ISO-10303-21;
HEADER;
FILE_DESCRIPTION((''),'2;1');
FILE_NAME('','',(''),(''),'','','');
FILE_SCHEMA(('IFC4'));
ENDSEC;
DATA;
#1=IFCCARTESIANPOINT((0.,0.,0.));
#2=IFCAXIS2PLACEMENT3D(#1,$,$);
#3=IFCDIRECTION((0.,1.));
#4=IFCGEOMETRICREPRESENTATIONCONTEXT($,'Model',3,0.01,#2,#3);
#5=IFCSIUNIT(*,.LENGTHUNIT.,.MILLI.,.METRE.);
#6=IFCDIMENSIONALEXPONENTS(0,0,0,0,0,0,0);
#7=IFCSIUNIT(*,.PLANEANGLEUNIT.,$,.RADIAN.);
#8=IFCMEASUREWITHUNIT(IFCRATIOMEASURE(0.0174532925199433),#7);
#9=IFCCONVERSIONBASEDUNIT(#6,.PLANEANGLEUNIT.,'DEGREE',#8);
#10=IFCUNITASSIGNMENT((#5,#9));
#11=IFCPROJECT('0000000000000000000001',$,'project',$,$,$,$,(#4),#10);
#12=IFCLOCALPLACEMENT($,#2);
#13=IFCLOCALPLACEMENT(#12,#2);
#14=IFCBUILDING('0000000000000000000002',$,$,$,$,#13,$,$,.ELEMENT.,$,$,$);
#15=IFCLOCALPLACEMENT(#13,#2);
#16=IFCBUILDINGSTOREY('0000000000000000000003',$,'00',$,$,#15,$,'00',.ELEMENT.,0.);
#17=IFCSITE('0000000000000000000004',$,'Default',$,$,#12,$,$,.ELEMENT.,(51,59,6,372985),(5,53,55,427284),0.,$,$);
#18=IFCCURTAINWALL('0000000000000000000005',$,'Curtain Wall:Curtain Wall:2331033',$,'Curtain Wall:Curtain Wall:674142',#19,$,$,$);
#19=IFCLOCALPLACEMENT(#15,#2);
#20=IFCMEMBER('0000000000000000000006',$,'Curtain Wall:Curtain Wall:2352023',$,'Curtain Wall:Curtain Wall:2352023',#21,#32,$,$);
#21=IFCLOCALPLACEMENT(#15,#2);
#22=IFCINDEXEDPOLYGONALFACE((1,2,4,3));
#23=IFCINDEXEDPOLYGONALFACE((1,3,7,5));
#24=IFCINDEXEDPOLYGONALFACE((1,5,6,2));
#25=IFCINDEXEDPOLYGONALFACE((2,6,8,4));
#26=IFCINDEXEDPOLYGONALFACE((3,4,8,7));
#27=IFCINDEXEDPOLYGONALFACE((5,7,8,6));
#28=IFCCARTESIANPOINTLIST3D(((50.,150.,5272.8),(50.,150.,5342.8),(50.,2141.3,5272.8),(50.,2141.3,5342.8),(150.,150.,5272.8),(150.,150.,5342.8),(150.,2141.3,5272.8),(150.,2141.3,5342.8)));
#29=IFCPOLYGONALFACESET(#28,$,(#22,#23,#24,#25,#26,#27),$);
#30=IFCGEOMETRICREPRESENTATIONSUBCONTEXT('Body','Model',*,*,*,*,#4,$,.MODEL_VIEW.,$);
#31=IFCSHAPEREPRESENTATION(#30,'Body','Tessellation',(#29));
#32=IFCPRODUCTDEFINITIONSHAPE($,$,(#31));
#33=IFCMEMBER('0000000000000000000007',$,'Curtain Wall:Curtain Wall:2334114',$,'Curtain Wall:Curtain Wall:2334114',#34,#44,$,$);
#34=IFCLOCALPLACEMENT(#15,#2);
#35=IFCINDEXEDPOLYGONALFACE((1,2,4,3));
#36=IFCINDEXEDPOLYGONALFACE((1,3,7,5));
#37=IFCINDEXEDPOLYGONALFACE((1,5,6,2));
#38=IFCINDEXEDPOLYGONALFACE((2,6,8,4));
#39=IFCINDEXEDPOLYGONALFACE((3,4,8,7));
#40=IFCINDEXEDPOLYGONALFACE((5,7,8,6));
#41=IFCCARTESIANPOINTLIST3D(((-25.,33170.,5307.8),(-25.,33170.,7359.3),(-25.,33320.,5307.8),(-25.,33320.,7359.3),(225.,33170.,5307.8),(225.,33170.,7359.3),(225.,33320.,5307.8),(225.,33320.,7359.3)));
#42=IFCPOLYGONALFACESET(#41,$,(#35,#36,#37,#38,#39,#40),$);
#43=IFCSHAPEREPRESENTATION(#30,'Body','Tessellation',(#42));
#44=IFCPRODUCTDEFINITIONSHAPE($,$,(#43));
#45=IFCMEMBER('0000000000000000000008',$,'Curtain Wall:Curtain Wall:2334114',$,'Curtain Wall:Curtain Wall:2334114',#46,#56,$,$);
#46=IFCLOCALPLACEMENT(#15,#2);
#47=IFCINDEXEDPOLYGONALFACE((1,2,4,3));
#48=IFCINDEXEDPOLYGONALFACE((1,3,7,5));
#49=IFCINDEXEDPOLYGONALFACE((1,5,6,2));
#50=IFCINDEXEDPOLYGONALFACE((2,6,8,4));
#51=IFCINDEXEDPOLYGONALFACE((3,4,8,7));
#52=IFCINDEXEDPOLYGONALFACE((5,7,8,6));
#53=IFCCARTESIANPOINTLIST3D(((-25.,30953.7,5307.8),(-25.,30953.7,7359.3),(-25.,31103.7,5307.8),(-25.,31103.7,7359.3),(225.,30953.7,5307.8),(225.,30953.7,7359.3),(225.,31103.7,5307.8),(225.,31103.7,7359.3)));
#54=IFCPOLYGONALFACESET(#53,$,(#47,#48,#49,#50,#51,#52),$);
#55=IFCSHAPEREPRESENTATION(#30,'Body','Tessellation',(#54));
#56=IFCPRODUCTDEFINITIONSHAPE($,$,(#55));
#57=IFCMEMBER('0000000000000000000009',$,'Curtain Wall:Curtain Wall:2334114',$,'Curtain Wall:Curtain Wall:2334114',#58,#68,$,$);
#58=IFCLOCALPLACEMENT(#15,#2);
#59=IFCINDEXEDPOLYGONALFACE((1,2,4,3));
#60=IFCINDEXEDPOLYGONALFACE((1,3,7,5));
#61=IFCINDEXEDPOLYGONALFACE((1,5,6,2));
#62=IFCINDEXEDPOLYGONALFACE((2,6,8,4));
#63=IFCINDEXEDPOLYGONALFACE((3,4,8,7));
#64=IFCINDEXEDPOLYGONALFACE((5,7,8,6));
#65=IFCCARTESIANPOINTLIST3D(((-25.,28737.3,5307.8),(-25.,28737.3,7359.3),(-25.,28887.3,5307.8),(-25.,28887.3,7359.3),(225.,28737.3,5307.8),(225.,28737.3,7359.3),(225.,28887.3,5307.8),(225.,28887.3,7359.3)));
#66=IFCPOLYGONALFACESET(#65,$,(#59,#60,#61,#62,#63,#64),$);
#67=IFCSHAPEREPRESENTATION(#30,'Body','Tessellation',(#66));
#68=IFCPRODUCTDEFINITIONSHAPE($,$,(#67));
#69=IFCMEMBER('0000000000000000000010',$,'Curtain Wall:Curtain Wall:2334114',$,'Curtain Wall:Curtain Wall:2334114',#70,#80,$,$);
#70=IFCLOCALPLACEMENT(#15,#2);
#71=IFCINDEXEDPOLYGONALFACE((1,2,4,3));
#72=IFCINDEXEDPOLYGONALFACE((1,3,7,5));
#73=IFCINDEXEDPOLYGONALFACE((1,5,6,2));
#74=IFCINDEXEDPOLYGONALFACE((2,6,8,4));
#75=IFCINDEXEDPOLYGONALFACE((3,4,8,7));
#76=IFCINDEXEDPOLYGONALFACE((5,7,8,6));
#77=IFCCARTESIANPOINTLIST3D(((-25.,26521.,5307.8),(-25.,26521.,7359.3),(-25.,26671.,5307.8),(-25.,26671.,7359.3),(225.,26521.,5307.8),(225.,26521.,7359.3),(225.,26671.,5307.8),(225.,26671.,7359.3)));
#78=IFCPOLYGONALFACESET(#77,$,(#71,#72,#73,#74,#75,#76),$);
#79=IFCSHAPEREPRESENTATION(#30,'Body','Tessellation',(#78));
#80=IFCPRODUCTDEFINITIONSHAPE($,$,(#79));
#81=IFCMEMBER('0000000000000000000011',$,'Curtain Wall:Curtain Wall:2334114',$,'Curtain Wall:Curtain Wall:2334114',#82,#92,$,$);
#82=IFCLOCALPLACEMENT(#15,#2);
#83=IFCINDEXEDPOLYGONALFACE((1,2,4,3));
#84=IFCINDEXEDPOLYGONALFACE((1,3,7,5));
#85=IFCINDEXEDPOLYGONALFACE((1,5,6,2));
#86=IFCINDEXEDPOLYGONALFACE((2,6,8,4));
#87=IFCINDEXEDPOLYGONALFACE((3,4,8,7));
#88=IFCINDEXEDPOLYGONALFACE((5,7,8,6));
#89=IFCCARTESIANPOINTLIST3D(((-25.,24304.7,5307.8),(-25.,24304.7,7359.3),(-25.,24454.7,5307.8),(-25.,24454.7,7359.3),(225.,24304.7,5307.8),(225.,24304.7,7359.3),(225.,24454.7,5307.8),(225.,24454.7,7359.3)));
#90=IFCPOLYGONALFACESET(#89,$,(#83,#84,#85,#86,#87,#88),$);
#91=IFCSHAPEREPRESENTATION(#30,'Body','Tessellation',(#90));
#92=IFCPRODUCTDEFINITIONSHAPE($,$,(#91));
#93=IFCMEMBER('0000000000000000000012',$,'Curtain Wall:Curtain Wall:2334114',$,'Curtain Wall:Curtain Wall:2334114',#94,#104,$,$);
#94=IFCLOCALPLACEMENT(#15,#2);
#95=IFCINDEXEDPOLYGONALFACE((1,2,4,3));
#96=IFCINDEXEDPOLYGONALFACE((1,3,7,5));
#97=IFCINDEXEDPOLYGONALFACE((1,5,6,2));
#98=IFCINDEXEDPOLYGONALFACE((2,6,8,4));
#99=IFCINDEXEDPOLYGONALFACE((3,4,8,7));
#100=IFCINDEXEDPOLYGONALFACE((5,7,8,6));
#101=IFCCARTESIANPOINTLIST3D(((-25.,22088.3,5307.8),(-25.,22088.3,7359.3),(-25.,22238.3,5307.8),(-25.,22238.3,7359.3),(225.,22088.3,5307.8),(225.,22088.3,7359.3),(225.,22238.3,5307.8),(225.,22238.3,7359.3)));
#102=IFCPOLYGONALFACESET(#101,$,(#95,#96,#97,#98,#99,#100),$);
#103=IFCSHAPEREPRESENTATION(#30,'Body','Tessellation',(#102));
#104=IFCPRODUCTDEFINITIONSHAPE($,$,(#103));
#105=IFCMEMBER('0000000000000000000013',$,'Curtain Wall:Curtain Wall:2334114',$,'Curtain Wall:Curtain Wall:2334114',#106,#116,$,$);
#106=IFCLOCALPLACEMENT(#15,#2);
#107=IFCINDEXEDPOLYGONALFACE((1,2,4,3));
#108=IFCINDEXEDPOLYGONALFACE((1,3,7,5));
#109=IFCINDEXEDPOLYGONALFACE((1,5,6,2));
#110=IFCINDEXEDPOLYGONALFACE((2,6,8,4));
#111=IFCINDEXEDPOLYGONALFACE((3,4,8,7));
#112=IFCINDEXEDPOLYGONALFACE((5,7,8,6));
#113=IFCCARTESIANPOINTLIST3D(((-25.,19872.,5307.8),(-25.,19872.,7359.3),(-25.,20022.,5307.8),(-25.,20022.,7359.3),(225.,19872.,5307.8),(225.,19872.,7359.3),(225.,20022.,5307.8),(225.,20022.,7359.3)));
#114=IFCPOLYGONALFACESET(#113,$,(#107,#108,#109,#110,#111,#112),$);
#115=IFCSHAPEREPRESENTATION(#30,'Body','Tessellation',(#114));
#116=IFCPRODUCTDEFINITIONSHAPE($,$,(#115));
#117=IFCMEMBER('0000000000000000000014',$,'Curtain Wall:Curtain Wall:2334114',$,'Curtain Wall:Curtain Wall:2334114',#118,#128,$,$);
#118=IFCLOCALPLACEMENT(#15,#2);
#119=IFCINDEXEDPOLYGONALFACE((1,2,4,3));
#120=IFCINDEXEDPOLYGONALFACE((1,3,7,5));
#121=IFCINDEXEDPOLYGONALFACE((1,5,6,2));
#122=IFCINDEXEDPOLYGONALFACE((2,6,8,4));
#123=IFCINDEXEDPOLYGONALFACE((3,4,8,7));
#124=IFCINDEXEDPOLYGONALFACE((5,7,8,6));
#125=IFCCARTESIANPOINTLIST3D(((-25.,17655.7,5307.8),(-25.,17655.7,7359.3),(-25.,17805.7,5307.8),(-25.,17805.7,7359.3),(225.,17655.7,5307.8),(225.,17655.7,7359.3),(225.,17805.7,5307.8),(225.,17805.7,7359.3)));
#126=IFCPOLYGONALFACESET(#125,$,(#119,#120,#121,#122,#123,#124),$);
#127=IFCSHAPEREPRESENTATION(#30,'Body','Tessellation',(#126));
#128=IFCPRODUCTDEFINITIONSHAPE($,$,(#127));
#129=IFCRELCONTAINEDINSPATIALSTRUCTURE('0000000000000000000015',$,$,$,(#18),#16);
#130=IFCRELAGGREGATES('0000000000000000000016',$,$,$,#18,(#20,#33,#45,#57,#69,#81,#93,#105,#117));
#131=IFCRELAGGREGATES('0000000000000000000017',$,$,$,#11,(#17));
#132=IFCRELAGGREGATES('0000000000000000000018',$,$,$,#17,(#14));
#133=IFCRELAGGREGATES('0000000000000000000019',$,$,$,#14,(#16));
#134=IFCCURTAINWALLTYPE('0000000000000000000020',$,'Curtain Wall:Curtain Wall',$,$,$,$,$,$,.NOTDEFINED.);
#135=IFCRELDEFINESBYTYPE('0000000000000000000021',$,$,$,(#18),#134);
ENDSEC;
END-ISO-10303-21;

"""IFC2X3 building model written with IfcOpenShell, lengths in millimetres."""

from ifc_helpers import new_model, entity, si_unit, converted_unit, direction, frame, frame_2d, origin, origin_2d_with_axis, place, context, subcontext, project, spatial, rectangle, extrude, type_object, element, aggregate, save


model = new_model("IFC2X3")

# Units and contexts
model_context = context("Model", 3, precision=0.01, world=origin(), true_north=direction((0.0, 1.0)))
body_context = subcontext(model_context, "Body", "Model", "MODEL_VIEW")
ifc_project = project(units=[si_unit("LENGTHUNIT", "METRE", prefix="MILLI"), converted_unit("PLANEANGLEUNIT", "DEGREE", entity("IfcRatioMeasure", 0.0174532925199433), si_unit("PLANEANGLEUNIT", "RADIAN"), dimensions=[0, 0, 0, 0, 0, 0, 0])], contexts=[model_context])

# Site, building, storey
site_placement = place(None, origin())
site = spatial("IfcSite", under=ifc_project, at=site_placement, Name="Default", CompositionType="ELEMENT", RefLatitude=(51, 59, 6, 372985), RefLongitude=(5, 53, 55, 427284), RefElevation=0.0)
building_placement = place(site_placement, origin())
building = spatial("IfcBuilding", under=site, at=building_placement, CompositionType="ELEMENT")
storey_placement = place(building_placement, origin())
storey = spatial("IfcBuildingStorey", under=building, at=storey_placement, Name="00", LongName="00", CompositionType="ELEMENT", Elevation=0.0)

# Curtain wall, members
curtain_wall_type = type_object("IfcCurtainWallType", Name="Curtain Wall:Curtain Wall", PredefinedType="NOTDEFINED")
curtain_wall_placement = place(storey_placement, origin())
curtain_wall = element("IfcCurtainWall", 1, at=curtain_wall_placement, inside=storey, type_object=curtain_wall_type, Name="Curtain Wall:Curtain Wall:2331033", ObjectType="Curtain Wall:Curtain Wall:674142")
member_1_placement = place(curtain_wall_placement, origin())
member_1 = element("IfcMember", 2, at=member_1_placement, Name="Curtain Wall:Curtain Wall:2352023", ObjectType="Curtain Wall:Curtain Wall:2352023", context=body_context, shape_type="SweptSolid", body=[
    extrude(rectangle(XDim=70.0, YDim=100.0, at=origin_2d_with_axis()), frame((100.0, 150.0, 5307.8), z_axis=(0.0, 1.0, 0.0), x_axis=(0.0, 0.0, -1.0)), (0.0, 0.0, 1.0), 1991.3),
])
member_2_placement = place(curtain_wall_placement, origin())
member_2 = element("IfcMember", 3, at=member_2_placement, Name="Curtain Wall:Curtain Wall:2334114", ObjectType="Curtain Wall:Curtain Wall:2334114", context=body_context, shape_type="SweptSolid", body=[
    extrude(rectangle(XDim=250.0, YDim=150.0, at=origin_2d_with_axis()), frame((100.0, 33245.0, 5307.8), z_axis=(0.0, 0.0, 1.0), x_axis=(-1.0, 0.0, 0.0)), (0.0, 0.0, 1.0), 2051.5),
])
member_3_placement = place(curtain_wall_placement, origin())
member_3 = element("IfcMember", 4, at=member_3_placement, Name="Curtain Wall:Curtain Wall:2334114", ObjectType="Curtain Wall:Curtain Wall:2334114", context=body_context, shape_type="SweptSolid", body=[
    extrude(rectangle(XDim=250.0, YDim=150.0, at=frame_2d((0.0, 0.0), x_axis=(1.0, 0.0))), frame((100.0, 31028.7, 5307.8), z_axis=(0.0, 0.0, 1.0), x_axis=(-1.0, 0.0, 0.0)), (0.0, 0.0, 1.0), 2051.5),
])
member_4_placement = place(curtain_wall_placement, origin())
member_4 = element("IfcMember", 5, at=member_4_placement, Name="Curtain Wall:Curtain Wall:2334114", ObjectType="Curtain Wall:Curtain Wall:2334114", context=body_context, shape_type="SweptSolid", body=[
    extrude(rectangle(XDim=250.0, YDim=150.0, at=frame_2d((0.0, 0.0), x_axis=(1.0, 0.0))), frame((100.0, 28812.3, 5307.8), z_axis=(0.0, 0.0, 1.0), x_axis=(-1.0, 0.0, 0.0)), (0.0, 0.0, 1.0), 2051.5),
])
member_5_placement = place(curtain_wall_placement, origin())
member_5 = element("IfcMember", 6, at=member_5_placement, Name="Curtain Wall:Curtain Wall:2334114", ObjectType="Curtain Wall:Curtain Wall:2334114", context=body_context, shape_type="SweptSolid", body=[
    extrude(rectangle(XDim=250.0, YDim=150.0, at=frame_2d((0.0, 0.0), x_axis=(1.0, 0.0))), frame((100.0, 26596.0, 5307.8), z_axis=(0.0, 0.0, 1.0), x_axis=(-1.0, 0.0, 0.0)), (0.0, 0.0, 1.0), 2051.5),
])
member_6_placement = place(curtain_wall_placement, origin())
member_6 = element("IfcMember", 7, at=member_6_placement, Name="Curtain Wall:Curtain Wall:2334114", ObjectType="Curtain Wall:Curtain Wall:2334114", context=body_context, shape_type="SweptSolid", body=[
    extrude(rectangle(XDim=250.0, YDim=150.0, at=origin_2d_with_axis()), frame((100.0, 24379.7, 5307.8), z_axis=(0.0, 0.0, 1.0), x_axis=(-1.0, 0.0, 0.0)), (0.0, 0.0, 1.0), 2051.5),
])
member_7_placement = place(curtain_wall_placement, origin())
member_7 = element("IfcMember", 8, at=member_7_placement, Name="Curtain Wall:Curtain Wall:2334114", ObjectType="Curtain Wall:Curtain Wall:2334114", context=body_context, shape_type="SweptSolid", body=[
    extrude(rectangle(XDim=250.0, YDim=150.0, at=origin_2d_with_axis()), frame((100.0, 22163.3, 5307.8), z_axis=(0.0, 0.0, 1.0), x_axis=(-1.0, 0.0, 0.0)), (0.0, 0.0, 1.0), 2051.5),
])
member_8_placement = place(curtain_wall_placement, origin())
member_8 = element("IfcMember", 9, at=member_8_placement, Name="Curtain Wall:Curtain Wall:2334114", ObjectType="Curtain Wall:Curtain Wall:2334114", context=body_context, shape_type="SweptSolid", body=[
    extrude(rectangle(XDim=250.0, YDim=150.0, at=frame_2d((0.0, 0.0), x_axis=(1.0, 0.0))), frame((100.0, 19947.0, 5307.8), z_axis=(0.0, 0.0, 1.0), x_axis=(-1.0, 0.0, 0.0)), (0.0, 0.0, 1.0), 2051.5),
])
member_9_placement = place(curtain_wall_placement, origin())
member_9 = element("IfcMember", 10, at=member_9_placement, Name="Curtain Wall:Curtain Wall:2334114", ObjectType="Curtain Wall:Curtain Wall:2334114", context=body_context, shape_type="SweptSolid", body=[
    extrude(rectangle(XDim=250.0, YDim=150.0, at=frame_2d((0.0, 0.0), x_axis=(1.0, 0.0))), frame((100.0, 17730.7, 5307.8), z_axis=(0.0, 0.0, 1.0), x_axis=(-1.0, 0.0, 0.0)), (0.0, 0.0, 1.0), 2051.5),
])
aggregate(curtain_wall, [member_1, member_2, member_3, member_4, member_5, member_6, member_7, member_8, member_9])

save(model, "model.ifc")
